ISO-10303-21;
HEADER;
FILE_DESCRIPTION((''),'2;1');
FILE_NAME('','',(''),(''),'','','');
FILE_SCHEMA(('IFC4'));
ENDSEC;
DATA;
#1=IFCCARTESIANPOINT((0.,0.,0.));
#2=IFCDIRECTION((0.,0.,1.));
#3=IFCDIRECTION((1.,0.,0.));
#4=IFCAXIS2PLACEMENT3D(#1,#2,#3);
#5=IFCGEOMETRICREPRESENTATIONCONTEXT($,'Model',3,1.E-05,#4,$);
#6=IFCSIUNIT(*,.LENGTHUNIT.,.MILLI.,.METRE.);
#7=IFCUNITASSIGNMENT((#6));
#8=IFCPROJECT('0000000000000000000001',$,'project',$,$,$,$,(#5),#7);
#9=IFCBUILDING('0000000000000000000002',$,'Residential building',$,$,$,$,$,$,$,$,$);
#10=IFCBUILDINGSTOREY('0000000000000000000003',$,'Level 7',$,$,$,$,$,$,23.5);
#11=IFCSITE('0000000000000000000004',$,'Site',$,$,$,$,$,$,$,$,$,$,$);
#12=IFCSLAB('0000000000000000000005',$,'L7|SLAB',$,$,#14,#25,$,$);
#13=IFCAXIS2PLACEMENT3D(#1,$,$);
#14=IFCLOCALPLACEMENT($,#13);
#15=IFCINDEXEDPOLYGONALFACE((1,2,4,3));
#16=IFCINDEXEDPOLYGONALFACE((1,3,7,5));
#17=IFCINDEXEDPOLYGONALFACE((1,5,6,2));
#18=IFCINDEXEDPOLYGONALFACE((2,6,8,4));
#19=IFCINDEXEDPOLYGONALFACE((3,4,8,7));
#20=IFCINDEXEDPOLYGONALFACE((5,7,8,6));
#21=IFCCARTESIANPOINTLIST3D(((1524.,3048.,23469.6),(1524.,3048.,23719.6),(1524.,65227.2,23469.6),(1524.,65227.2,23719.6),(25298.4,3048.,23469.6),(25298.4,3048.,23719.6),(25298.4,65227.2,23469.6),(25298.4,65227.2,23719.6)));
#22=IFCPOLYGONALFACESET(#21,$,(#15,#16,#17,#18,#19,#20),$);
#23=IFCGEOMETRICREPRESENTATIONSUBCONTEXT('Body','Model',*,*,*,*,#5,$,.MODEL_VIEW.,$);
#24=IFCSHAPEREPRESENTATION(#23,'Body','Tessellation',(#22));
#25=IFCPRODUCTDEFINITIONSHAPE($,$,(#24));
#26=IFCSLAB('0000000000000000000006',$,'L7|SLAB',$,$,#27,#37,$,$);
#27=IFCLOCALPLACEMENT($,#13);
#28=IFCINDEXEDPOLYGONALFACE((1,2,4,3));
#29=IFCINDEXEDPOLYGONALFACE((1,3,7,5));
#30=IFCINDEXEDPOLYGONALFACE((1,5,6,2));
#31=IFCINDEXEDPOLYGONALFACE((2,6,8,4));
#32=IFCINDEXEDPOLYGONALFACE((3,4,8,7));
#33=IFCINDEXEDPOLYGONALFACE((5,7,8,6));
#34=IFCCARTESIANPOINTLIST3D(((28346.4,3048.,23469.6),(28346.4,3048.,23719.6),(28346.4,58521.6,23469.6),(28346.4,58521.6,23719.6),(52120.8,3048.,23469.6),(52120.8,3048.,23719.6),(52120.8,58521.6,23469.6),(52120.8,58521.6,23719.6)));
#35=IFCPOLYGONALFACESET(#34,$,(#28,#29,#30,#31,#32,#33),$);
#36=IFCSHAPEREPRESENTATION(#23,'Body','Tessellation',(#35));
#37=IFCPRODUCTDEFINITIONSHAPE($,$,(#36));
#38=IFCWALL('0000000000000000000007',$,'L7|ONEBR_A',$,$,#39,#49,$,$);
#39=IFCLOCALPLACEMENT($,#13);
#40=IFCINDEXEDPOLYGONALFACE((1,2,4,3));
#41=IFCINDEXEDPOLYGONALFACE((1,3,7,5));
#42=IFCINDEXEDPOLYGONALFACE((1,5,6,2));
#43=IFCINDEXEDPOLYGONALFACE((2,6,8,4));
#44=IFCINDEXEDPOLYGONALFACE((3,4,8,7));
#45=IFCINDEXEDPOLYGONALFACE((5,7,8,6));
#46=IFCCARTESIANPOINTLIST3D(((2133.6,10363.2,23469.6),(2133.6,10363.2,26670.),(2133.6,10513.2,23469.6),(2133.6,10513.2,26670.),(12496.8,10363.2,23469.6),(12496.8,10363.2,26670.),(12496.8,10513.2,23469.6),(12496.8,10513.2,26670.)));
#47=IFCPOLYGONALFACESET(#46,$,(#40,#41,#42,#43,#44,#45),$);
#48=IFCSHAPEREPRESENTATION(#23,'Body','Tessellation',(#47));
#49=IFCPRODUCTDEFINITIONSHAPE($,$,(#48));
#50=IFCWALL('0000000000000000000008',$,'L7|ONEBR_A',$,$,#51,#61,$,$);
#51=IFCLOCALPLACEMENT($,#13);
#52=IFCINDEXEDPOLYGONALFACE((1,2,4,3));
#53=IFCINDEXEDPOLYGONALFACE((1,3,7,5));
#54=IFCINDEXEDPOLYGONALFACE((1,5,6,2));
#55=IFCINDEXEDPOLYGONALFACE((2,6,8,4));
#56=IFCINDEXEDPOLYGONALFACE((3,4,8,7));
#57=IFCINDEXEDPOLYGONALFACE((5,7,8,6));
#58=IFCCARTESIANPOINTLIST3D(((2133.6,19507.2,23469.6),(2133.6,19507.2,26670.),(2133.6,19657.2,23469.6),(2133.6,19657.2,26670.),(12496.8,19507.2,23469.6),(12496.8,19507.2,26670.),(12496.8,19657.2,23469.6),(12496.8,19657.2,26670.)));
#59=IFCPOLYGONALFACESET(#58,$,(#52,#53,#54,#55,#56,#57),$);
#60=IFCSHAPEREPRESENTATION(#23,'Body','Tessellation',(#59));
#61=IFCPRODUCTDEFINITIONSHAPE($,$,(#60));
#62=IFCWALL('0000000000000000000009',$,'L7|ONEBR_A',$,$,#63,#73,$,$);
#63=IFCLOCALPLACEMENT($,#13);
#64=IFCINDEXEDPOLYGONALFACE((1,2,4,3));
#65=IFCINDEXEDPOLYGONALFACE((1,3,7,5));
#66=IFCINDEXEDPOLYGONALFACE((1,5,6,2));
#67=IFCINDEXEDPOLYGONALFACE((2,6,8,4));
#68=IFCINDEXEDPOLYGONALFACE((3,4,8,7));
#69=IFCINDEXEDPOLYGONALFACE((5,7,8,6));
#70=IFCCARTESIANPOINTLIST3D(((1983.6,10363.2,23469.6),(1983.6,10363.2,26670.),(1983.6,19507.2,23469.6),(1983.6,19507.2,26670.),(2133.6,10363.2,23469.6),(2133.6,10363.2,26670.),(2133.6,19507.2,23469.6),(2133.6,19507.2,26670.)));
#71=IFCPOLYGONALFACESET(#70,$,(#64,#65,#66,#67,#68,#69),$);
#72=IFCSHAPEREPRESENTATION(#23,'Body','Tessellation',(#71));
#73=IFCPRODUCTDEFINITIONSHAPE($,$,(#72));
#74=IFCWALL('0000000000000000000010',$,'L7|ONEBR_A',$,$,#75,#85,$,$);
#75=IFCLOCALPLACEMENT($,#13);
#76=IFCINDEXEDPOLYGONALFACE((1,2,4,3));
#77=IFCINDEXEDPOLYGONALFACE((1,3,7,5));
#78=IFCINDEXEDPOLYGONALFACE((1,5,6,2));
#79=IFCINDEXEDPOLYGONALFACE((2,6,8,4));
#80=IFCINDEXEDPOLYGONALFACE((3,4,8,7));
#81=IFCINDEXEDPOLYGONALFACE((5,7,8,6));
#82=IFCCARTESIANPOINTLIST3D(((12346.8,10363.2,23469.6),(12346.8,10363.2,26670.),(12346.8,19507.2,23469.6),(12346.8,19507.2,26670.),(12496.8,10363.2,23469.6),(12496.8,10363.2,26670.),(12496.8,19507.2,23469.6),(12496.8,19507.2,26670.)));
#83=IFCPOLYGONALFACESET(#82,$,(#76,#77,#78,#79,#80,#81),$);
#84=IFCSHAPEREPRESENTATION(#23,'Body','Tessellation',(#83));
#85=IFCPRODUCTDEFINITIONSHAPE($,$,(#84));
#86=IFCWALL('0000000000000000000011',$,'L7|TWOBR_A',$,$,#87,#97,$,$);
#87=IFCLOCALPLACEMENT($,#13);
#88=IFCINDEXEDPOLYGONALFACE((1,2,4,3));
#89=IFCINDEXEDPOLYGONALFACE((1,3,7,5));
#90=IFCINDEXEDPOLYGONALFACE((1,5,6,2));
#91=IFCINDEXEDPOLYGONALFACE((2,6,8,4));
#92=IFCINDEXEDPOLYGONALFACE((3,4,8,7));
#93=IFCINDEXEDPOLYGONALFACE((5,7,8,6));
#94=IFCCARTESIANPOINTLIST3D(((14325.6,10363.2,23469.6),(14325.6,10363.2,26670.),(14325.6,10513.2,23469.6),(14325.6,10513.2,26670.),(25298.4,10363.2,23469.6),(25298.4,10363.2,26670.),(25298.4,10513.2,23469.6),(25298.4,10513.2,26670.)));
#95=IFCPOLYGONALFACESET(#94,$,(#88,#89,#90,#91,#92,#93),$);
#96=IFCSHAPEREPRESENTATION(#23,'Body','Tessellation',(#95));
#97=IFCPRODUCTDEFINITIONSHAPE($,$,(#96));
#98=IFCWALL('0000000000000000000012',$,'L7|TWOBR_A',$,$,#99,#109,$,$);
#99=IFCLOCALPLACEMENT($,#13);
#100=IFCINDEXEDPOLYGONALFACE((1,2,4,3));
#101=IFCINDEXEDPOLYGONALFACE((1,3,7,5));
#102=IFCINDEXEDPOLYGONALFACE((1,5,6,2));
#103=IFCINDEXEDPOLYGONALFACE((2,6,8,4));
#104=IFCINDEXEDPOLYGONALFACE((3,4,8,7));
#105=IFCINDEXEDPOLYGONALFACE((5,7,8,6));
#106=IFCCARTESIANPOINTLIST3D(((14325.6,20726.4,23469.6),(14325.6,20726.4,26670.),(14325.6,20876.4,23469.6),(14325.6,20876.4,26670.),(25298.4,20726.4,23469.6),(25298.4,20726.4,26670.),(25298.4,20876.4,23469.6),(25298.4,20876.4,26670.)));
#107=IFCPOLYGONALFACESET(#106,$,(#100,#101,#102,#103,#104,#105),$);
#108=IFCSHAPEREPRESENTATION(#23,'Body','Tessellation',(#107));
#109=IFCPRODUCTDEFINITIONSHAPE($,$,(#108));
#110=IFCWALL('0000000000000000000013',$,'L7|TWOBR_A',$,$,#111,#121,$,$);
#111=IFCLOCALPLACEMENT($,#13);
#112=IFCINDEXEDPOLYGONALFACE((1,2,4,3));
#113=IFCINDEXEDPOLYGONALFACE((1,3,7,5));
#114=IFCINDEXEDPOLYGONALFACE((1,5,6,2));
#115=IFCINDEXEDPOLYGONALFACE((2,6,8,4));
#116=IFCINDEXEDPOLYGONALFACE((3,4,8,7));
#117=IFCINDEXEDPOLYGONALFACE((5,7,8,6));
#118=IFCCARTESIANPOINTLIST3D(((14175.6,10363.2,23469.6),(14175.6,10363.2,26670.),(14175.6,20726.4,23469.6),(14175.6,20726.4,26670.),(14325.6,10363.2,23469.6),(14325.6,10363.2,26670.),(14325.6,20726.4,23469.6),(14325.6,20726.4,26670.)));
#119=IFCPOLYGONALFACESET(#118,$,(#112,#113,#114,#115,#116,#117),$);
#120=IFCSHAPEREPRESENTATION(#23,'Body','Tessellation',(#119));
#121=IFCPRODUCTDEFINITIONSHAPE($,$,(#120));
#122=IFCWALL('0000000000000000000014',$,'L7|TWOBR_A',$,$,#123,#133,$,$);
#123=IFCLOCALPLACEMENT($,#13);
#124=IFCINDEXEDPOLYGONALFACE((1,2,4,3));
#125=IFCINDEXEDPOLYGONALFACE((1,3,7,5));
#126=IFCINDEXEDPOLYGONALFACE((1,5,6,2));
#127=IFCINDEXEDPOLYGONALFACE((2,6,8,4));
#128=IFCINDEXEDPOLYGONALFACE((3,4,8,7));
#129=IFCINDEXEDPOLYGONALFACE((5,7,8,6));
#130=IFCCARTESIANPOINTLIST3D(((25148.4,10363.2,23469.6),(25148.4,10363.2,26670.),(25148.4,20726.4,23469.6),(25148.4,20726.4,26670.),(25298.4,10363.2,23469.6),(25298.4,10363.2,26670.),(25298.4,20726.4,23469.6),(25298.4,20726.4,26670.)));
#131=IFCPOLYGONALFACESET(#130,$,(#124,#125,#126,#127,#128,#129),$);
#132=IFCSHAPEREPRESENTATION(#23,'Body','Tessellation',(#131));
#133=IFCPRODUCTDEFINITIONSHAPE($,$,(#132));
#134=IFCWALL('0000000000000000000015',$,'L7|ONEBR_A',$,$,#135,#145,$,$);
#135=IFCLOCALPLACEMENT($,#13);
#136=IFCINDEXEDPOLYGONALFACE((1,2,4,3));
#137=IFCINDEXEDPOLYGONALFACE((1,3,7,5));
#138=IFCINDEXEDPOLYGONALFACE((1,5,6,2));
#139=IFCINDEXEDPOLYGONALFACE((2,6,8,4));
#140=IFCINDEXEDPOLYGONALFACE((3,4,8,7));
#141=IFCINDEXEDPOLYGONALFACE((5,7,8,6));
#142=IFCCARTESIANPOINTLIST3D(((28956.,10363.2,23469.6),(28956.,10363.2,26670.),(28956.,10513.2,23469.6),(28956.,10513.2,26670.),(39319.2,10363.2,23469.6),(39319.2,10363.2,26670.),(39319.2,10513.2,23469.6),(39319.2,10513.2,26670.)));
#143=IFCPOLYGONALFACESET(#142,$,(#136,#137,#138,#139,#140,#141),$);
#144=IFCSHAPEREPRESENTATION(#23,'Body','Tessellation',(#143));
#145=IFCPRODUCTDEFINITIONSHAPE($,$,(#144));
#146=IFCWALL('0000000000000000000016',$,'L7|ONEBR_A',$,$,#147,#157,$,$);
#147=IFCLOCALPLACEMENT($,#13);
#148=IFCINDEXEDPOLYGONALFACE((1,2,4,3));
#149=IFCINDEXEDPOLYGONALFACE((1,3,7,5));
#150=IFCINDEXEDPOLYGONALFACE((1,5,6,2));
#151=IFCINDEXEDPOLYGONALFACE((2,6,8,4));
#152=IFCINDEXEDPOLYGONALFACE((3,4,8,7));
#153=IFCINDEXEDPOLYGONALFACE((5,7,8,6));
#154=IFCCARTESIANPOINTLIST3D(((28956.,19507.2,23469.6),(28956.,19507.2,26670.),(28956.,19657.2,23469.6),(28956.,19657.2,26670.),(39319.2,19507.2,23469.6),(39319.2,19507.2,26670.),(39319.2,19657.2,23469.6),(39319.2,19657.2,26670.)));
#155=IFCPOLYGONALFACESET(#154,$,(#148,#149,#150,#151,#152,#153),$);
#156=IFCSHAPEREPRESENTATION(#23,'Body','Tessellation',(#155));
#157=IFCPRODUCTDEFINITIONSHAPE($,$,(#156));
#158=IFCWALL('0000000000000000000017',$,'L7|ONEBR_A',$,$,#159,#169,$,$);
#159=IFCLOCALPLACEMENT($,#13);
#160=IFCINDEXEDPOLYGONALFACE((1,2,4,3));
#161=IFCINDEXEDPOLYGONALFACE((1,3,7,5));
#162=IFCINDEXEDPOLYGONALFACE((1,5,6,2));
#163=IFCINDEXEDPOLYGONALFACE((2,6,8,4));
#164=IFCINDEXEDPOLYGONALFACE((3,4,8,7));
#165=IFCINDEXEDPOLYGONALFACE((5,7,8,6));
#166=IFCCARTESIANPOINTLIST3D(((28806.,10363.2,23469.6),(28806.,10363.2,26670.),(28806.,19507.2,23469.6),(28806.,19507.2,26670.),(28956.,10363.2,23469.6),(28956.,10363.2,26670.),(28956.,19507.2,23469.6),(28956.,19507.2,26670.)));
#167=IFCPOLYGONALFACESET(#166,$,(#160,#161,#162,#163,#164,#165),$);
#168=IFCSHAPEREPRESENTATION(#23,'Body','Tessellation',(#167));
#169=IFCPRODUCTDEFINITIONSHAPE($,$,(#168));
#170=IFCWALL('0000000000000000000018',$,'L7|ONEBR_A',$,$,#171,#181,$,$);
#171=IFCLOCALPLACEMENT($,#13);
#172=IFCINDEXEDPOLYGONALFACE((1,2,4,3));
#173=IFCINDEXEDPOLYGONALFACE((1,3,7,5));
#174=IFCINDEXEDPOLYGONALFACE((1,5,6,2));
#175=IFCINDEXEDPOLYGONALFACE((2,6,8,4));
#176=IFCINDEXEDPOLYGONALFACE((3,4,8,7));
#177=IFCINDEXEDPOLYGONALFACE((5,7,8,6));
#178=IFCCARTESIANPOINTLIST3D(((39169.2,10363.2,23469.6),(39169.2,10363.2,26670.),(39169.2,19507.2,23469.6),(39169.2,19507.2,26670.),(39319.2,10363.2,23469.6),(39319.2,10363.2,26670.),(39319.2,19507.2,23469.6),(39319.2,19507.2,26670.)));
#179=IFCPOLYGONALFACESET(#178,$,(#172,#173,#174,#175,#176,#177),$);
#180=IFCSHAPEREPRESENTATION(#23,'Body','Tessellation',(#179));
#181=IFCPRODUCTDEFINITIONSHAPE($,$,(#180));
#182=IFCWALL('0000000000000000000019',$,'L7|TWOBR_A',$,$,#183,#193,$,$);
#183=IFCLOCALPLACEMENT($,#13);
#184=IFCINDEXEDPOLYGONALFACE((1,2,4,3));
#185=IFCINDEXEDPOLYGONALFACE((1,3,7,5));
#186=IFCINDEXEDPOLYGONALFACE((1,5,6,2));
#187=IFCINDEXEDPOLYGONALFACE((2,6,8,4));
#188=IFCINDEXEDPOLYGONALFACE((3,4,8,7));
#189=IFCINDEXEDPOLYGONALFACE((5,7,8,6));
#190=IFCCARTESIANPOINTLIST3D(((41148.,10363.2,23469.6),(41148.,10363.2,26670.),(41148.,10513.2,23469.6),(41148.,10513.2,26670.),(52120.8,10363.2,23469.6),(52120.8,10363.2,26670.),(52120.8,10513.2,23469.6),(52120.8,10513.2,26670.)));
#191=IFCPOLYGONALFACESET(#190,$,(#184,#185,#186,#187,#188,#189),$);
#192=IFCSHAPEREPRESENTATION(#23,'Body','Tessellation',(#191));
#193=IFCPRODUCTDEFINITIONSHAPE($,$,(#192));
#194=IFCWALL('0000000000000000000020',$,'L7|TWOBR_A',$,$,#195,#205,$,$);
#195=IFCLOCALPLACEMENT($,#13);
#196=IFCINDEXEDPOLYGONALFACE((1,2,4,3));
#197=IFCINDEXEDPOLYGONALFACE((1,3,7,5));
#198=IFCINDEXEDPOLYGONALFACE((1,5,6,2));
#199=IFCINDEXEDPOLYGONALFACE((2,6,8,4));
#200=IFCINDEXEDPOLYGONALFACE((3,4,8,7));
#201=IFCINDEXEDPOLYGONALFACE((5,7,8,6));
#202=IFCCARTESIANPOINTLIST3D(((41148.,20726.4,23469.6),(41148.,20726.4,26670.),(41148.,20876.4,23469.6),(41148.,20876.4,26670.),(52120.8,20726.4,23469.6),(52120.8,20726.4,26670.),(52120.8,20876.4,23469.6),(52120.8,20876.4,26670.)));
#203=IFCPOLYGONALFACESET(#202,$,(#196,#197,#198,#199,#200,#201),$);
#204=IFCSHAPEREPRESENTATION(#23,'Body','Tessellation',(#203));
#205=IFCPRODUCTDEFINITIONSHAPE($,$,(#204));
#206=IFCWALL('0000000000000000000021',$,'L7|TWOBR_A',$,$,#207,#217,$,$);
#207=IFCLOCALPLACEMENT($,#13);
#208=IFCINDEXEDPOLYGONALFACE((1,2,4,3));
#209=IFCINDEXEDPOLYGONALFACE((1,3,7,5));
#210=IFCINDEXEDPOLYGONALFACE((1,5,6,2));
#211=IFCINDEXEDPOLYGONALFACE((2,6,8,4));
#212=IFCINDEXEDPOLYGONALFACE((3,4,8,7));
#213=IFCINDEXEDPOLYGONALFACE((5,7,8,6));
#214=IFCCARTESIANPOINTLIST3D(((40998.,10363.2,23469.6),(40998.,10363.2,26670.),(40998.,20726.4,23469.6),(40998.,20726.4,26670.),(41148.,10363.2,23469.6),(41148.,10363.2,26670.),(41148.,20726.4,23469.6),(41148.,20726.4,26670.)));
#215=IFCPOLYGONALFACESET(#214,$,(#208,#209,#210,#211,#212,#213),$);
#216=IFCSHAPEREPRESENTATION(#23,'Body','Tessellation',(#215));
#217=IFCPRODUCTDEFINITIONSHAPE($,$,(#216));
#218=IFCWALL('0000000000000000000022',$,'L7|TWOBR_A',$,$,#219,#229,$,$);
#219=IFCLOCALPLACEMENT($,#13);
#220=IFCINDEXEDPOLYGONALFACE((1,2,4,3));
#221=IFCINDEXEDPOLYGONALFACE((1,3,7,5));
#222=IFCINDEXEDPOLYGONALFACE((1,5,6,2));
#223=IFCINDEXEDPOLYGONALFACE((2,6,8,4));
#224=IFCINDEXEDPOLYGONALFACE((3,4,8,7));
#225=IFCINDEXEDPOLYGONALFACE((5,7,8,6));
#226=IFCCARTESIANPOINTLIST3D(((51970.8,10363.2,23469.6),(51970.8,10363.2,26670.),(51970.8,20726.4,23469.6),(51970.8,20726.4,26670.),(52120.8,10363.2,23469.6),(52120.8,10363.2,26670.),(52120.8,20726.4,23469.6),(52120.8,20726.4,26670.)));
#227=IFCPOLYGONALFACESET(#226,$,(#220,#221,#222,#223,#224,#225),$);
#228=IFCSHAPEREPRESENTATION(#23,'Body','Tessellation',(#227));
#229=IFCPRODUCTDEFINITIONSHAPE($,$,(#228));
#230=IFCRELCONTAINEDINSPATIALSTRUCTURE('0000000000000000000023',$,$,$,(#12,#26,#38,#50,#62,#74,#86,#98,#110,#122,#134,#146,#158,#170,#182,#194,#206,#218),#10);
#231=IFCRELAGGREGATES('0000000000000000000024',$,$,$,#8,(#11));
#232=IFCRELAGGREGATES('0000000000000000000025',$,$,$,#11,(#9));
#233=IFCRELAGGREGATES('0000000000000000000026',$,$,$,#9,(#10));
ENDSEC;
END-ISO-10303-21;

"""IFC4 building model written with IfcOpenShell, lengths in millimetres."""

from ifc_helpers import new_model, si_unit, frame, origin_with_axes, place, context, subcontext, project, spatial, indexed_curve, outline, extrude, element, save


model = new_model("IFC4")

# Units and contexts
model_context = context("Model", 3, precision=1e-05, world=origin_with_axes())
body_context = subcontext(model_context, "Body", "Model", "MODEL_VIEW")
ifc_project = project(units=[si_unit("LENGTHUNIT", "METRE", prefix="MILLI")], contexts=[model_context])

# Site, building, storey
site = spatial("IfcSite", under=ifc_project, Name="Site")
building = spatial("IfcBuilding", under=site, Name="Residential building")
storey = spatial("IfcBuildingStorey", under=building, Name="Level 7", Elevation=23.5)

# Slabs
slab_1_placement = place(None, frame((1524.0, 3048.0, 23469.6), z_axis=(0.0, 0.0, 1.0), x_axis=(1.0, 0.0, 0.0)))
element("IfcSlab", 1, at=slab_1_placement, inside=storey, Name="L7|SLAB", context=body_context, shape_type="SweptSolid", body=[
    extrude(outline(indexed_curve([(0.0, 0.0), (23774.4, 0.0), (23774.4, 62179.2), (0.0, 62179.2), (0.0, 0.0)])), None, (0.0, 0.0, 1.0), 250.0),
])
slab_2_placement = place(None, frame((28346.4, 3048.0, 23469.6), z_axis=(0.0, 0.0, 1.0), x_axis=(1.0, 0.0, 0.0)))
element("IfcSlab", 2, at=slab_2_placement, inside=storey, Name="L7|SLAB", context=body_context, shape_type="SweptSolid", body=[
    extrude(outline(indexed_curve([(0.0, 0.0), (23774.4, 0.0), (23774.4, 55473.6), (0.0, 55473.6), (0.0, 0.0)])), None, (0.0, 0.0, 1.0), 250.0),
])

# Walls
for number, where, z_axis, x_axis, name in (
    (3, (2133.6, 10363.2, 23469.6), (0.0, 0.0, 1.0), (1.0, 0.0, 0.0), "L7|ONEBR_A"),
    (4, (2133.6, 19507.2, 23469.6), (0.0, 0.0, 1.0), (1.0, 0.0, 0.0), "L7|ONEBR_A"),
):
    element("IfcWall", number, at=place(None, frame(where, z_axis=z_axis, x_axis=x_axis)), inside=storey, Name=name, context=body_context, shape_type="SweptSolid", body=[
        extrude(outline(indexed_curve([(0.0, 0.0), (0.0, 150.0), (10363.2, 150.0), (10363.2, 0.0), (0.0, 0.0)], self_intersect=False)), origin_with_axes(), (0.0, 0.0, 1.0), 3200.4),
    ])
for number, where, z_axis, x_axis, name in (
    (5, (2133.6, 10363.2, 23469.6), (0.0, 0.0, 1.0), (0.0, 1.0, 0.0), "L7|ONEBR_A"),
    (6, (12496.8, 10363.2, 23469.6), (0.0, 0.0, 1.0), (0.0, 1.0, 0.0), "L7|ONEBR_A"),
):
    element("IfcWall", number, at=place(None, frame(where, z_axis=z_axis, x_axis=x_axis)), inside=storey, Name=name, context=body_context, shape_type="SweptSolid", body=[
        extrude(outline(indexed_curve([(0.0, 0.0), (0.0, 150.0), (9144.0, 150.0), (9144.0, 0.0), (0.0, 0.0)], self_intersect=False)), origin_with_axes(), (0.0, 0.0, 1.0), 3200.4),
    ])
for number, where, z_axis, x_axis, name in (
    (7, (14325.6, 10363.2, 23469.6), (0.0, 0.0, 1.0), (1.0, 0.0, 0.0), "L7|TWOBR_A"),
    (8, (14325.6, 20726.4, 23469.6), (0.0, 0.0, 1.0), (1.0, 0.0, 0.0), "L7|TWOBR_A"),
):
    element("IfcWall", number, at=place(None, frame(where, z_axis=z_axis, x_axis=x_axis)), inside=storey, Name=name, context=body_context, shape_type="SweptSolid", body=[
        extrude(outline(indexed_curve([(0.0, 0.0), (0.0, 150.0), (10972.8, 150.0), (10972.8, 0.0), (0.0, 0.0)], self_intersect=False)), origin_with_axes(), (0.0, 0.0, 1.0), 3200.4),
    ])
for number, where, z_axis, x_axis, name in (
    (9, (14325.6, 10363.2, 23469.6), (0.0, 0.0, 1.0), (0.0, 1.0, 0.0), "L7|TWOBR_A"),
    (10, (25298.4, 10363.2, 23469.6), (0.0, 0.0, 1.0), (0.0, 1.0, 0.0), "L7|TWOBR_A"),
    (11, (28956.0, 10363.2, 23469.6), (0.0, 0.0, 1.0), (1.0, 0.0, 0.0), "L7|ONEBR_A"),
    (12, (28956.0, 19507.2, 23469.6), (0.0, 0.0, 1.0), (1.0, 0.0, 0.0), "L7|ONEBR_A"),
):
    element("IfcWall", number, at=place(None, frame(where, z_axis=z_axis, x_axis=x_axis)), inside=storey, Name=name, context=body_context, shape_type="SweptSolid", body=[
        extrude(outline(indexed_curve([(0.0, 0.0), (0.0, 150.0), (10363.2, 150.0), (10363.2, 0.0), (0.0, 0.0)], self_intersect=False)), origin_with_axes(), (0.0, 0.0, 1.0), 3200.4),
    ])
for number, where, z_axis, x_axis, name in (
    (13, (28956.0, 10363.2, 23469.6), (0.0, 0.0, 1.0), (0.0, 1.0, 0.0), "L7|ONEBR_A"),
    (14, (39319.2, 10363.2, 23469.6), (0.0, 0.0, 1.0), (0.0, 1.0, 0.0), "L7|ONEBR_A"),
):
    element("IfcWall", number, at=place(None, frame(where, z_axis=z_axis, x_axis=x_axis)), inside=storey, Name=name, context=body_context, shape_type="SweptSolid", body=[
        extrude(outline(indexed_curve([(0.0, 0.0), (0.0, 150.0), (9144.0, 150.0), (9144.0, 0.0), (0.0, 0.0)], self_intersect=False)), origin_with_axes(), (0.0, 0.0, 1.0), 3200.4),
    ])
for number, where, z_axis, x_axis, name in (
    (15, (41148.0, 10363.2, 23469.6), (0.0, 0.0, 1.0), (1.0, 0.0, 0.0), "L7|TWOBR_A"),
    (16, (41148.0, 20726.4, 23469.6), (0.0, 0.0, 1.0), (1.0, 0.0, 0.0), "L7|TWOBR_A"),
):
    element("IfcWall", number, at=place(None, frame(where, z_axis=z_axis, x_axis=x_axis)), inside=storey, Name=name, context=body_context, shape_type="SweptSolid", body=[
        extrude(outline(indexed_curve([(0.0, 0.0), (0.0, 150.0), (10972.8, 150.0), (10972.8, 0.0), (0.0, 0.0)], self_intersect=False)), origin_with_axes(), (0.0, 0.0, 1.0), 3200.4),
    ])
for number, where, z_axis, x_axis, name in (
    (17, (41148.0, 10363.2, 23469.6), (0.0, 0.0, 1.0), (0.0, 1.0, 0.0), "L7|TWOBR_A"),
    (18, (52120.8, 10363.2, 23469.6), (0.0, 0.0, 1.0), (0.0, 1.0, 0.0), "L7|TWOBR_A"),
):
    element("IfcWall", number, at=place(None, frame(where, z_axis=z_axis, x_axis=x_axis)), inside=storey, Name=name, context=body_context, shape_type="SweptSolid", body=[
        extrude(outline(indexed_curve([(0.0, 0.0), (0.0, 150.0), (10363.2, 150.0), (10363.2, 0.0), (0.0, 0.0)], self_intersect=False)), origin_with_axes(), (0.0, 0.0, 1.0), 3200.4),
    ])

save(model, "model.ifc")
